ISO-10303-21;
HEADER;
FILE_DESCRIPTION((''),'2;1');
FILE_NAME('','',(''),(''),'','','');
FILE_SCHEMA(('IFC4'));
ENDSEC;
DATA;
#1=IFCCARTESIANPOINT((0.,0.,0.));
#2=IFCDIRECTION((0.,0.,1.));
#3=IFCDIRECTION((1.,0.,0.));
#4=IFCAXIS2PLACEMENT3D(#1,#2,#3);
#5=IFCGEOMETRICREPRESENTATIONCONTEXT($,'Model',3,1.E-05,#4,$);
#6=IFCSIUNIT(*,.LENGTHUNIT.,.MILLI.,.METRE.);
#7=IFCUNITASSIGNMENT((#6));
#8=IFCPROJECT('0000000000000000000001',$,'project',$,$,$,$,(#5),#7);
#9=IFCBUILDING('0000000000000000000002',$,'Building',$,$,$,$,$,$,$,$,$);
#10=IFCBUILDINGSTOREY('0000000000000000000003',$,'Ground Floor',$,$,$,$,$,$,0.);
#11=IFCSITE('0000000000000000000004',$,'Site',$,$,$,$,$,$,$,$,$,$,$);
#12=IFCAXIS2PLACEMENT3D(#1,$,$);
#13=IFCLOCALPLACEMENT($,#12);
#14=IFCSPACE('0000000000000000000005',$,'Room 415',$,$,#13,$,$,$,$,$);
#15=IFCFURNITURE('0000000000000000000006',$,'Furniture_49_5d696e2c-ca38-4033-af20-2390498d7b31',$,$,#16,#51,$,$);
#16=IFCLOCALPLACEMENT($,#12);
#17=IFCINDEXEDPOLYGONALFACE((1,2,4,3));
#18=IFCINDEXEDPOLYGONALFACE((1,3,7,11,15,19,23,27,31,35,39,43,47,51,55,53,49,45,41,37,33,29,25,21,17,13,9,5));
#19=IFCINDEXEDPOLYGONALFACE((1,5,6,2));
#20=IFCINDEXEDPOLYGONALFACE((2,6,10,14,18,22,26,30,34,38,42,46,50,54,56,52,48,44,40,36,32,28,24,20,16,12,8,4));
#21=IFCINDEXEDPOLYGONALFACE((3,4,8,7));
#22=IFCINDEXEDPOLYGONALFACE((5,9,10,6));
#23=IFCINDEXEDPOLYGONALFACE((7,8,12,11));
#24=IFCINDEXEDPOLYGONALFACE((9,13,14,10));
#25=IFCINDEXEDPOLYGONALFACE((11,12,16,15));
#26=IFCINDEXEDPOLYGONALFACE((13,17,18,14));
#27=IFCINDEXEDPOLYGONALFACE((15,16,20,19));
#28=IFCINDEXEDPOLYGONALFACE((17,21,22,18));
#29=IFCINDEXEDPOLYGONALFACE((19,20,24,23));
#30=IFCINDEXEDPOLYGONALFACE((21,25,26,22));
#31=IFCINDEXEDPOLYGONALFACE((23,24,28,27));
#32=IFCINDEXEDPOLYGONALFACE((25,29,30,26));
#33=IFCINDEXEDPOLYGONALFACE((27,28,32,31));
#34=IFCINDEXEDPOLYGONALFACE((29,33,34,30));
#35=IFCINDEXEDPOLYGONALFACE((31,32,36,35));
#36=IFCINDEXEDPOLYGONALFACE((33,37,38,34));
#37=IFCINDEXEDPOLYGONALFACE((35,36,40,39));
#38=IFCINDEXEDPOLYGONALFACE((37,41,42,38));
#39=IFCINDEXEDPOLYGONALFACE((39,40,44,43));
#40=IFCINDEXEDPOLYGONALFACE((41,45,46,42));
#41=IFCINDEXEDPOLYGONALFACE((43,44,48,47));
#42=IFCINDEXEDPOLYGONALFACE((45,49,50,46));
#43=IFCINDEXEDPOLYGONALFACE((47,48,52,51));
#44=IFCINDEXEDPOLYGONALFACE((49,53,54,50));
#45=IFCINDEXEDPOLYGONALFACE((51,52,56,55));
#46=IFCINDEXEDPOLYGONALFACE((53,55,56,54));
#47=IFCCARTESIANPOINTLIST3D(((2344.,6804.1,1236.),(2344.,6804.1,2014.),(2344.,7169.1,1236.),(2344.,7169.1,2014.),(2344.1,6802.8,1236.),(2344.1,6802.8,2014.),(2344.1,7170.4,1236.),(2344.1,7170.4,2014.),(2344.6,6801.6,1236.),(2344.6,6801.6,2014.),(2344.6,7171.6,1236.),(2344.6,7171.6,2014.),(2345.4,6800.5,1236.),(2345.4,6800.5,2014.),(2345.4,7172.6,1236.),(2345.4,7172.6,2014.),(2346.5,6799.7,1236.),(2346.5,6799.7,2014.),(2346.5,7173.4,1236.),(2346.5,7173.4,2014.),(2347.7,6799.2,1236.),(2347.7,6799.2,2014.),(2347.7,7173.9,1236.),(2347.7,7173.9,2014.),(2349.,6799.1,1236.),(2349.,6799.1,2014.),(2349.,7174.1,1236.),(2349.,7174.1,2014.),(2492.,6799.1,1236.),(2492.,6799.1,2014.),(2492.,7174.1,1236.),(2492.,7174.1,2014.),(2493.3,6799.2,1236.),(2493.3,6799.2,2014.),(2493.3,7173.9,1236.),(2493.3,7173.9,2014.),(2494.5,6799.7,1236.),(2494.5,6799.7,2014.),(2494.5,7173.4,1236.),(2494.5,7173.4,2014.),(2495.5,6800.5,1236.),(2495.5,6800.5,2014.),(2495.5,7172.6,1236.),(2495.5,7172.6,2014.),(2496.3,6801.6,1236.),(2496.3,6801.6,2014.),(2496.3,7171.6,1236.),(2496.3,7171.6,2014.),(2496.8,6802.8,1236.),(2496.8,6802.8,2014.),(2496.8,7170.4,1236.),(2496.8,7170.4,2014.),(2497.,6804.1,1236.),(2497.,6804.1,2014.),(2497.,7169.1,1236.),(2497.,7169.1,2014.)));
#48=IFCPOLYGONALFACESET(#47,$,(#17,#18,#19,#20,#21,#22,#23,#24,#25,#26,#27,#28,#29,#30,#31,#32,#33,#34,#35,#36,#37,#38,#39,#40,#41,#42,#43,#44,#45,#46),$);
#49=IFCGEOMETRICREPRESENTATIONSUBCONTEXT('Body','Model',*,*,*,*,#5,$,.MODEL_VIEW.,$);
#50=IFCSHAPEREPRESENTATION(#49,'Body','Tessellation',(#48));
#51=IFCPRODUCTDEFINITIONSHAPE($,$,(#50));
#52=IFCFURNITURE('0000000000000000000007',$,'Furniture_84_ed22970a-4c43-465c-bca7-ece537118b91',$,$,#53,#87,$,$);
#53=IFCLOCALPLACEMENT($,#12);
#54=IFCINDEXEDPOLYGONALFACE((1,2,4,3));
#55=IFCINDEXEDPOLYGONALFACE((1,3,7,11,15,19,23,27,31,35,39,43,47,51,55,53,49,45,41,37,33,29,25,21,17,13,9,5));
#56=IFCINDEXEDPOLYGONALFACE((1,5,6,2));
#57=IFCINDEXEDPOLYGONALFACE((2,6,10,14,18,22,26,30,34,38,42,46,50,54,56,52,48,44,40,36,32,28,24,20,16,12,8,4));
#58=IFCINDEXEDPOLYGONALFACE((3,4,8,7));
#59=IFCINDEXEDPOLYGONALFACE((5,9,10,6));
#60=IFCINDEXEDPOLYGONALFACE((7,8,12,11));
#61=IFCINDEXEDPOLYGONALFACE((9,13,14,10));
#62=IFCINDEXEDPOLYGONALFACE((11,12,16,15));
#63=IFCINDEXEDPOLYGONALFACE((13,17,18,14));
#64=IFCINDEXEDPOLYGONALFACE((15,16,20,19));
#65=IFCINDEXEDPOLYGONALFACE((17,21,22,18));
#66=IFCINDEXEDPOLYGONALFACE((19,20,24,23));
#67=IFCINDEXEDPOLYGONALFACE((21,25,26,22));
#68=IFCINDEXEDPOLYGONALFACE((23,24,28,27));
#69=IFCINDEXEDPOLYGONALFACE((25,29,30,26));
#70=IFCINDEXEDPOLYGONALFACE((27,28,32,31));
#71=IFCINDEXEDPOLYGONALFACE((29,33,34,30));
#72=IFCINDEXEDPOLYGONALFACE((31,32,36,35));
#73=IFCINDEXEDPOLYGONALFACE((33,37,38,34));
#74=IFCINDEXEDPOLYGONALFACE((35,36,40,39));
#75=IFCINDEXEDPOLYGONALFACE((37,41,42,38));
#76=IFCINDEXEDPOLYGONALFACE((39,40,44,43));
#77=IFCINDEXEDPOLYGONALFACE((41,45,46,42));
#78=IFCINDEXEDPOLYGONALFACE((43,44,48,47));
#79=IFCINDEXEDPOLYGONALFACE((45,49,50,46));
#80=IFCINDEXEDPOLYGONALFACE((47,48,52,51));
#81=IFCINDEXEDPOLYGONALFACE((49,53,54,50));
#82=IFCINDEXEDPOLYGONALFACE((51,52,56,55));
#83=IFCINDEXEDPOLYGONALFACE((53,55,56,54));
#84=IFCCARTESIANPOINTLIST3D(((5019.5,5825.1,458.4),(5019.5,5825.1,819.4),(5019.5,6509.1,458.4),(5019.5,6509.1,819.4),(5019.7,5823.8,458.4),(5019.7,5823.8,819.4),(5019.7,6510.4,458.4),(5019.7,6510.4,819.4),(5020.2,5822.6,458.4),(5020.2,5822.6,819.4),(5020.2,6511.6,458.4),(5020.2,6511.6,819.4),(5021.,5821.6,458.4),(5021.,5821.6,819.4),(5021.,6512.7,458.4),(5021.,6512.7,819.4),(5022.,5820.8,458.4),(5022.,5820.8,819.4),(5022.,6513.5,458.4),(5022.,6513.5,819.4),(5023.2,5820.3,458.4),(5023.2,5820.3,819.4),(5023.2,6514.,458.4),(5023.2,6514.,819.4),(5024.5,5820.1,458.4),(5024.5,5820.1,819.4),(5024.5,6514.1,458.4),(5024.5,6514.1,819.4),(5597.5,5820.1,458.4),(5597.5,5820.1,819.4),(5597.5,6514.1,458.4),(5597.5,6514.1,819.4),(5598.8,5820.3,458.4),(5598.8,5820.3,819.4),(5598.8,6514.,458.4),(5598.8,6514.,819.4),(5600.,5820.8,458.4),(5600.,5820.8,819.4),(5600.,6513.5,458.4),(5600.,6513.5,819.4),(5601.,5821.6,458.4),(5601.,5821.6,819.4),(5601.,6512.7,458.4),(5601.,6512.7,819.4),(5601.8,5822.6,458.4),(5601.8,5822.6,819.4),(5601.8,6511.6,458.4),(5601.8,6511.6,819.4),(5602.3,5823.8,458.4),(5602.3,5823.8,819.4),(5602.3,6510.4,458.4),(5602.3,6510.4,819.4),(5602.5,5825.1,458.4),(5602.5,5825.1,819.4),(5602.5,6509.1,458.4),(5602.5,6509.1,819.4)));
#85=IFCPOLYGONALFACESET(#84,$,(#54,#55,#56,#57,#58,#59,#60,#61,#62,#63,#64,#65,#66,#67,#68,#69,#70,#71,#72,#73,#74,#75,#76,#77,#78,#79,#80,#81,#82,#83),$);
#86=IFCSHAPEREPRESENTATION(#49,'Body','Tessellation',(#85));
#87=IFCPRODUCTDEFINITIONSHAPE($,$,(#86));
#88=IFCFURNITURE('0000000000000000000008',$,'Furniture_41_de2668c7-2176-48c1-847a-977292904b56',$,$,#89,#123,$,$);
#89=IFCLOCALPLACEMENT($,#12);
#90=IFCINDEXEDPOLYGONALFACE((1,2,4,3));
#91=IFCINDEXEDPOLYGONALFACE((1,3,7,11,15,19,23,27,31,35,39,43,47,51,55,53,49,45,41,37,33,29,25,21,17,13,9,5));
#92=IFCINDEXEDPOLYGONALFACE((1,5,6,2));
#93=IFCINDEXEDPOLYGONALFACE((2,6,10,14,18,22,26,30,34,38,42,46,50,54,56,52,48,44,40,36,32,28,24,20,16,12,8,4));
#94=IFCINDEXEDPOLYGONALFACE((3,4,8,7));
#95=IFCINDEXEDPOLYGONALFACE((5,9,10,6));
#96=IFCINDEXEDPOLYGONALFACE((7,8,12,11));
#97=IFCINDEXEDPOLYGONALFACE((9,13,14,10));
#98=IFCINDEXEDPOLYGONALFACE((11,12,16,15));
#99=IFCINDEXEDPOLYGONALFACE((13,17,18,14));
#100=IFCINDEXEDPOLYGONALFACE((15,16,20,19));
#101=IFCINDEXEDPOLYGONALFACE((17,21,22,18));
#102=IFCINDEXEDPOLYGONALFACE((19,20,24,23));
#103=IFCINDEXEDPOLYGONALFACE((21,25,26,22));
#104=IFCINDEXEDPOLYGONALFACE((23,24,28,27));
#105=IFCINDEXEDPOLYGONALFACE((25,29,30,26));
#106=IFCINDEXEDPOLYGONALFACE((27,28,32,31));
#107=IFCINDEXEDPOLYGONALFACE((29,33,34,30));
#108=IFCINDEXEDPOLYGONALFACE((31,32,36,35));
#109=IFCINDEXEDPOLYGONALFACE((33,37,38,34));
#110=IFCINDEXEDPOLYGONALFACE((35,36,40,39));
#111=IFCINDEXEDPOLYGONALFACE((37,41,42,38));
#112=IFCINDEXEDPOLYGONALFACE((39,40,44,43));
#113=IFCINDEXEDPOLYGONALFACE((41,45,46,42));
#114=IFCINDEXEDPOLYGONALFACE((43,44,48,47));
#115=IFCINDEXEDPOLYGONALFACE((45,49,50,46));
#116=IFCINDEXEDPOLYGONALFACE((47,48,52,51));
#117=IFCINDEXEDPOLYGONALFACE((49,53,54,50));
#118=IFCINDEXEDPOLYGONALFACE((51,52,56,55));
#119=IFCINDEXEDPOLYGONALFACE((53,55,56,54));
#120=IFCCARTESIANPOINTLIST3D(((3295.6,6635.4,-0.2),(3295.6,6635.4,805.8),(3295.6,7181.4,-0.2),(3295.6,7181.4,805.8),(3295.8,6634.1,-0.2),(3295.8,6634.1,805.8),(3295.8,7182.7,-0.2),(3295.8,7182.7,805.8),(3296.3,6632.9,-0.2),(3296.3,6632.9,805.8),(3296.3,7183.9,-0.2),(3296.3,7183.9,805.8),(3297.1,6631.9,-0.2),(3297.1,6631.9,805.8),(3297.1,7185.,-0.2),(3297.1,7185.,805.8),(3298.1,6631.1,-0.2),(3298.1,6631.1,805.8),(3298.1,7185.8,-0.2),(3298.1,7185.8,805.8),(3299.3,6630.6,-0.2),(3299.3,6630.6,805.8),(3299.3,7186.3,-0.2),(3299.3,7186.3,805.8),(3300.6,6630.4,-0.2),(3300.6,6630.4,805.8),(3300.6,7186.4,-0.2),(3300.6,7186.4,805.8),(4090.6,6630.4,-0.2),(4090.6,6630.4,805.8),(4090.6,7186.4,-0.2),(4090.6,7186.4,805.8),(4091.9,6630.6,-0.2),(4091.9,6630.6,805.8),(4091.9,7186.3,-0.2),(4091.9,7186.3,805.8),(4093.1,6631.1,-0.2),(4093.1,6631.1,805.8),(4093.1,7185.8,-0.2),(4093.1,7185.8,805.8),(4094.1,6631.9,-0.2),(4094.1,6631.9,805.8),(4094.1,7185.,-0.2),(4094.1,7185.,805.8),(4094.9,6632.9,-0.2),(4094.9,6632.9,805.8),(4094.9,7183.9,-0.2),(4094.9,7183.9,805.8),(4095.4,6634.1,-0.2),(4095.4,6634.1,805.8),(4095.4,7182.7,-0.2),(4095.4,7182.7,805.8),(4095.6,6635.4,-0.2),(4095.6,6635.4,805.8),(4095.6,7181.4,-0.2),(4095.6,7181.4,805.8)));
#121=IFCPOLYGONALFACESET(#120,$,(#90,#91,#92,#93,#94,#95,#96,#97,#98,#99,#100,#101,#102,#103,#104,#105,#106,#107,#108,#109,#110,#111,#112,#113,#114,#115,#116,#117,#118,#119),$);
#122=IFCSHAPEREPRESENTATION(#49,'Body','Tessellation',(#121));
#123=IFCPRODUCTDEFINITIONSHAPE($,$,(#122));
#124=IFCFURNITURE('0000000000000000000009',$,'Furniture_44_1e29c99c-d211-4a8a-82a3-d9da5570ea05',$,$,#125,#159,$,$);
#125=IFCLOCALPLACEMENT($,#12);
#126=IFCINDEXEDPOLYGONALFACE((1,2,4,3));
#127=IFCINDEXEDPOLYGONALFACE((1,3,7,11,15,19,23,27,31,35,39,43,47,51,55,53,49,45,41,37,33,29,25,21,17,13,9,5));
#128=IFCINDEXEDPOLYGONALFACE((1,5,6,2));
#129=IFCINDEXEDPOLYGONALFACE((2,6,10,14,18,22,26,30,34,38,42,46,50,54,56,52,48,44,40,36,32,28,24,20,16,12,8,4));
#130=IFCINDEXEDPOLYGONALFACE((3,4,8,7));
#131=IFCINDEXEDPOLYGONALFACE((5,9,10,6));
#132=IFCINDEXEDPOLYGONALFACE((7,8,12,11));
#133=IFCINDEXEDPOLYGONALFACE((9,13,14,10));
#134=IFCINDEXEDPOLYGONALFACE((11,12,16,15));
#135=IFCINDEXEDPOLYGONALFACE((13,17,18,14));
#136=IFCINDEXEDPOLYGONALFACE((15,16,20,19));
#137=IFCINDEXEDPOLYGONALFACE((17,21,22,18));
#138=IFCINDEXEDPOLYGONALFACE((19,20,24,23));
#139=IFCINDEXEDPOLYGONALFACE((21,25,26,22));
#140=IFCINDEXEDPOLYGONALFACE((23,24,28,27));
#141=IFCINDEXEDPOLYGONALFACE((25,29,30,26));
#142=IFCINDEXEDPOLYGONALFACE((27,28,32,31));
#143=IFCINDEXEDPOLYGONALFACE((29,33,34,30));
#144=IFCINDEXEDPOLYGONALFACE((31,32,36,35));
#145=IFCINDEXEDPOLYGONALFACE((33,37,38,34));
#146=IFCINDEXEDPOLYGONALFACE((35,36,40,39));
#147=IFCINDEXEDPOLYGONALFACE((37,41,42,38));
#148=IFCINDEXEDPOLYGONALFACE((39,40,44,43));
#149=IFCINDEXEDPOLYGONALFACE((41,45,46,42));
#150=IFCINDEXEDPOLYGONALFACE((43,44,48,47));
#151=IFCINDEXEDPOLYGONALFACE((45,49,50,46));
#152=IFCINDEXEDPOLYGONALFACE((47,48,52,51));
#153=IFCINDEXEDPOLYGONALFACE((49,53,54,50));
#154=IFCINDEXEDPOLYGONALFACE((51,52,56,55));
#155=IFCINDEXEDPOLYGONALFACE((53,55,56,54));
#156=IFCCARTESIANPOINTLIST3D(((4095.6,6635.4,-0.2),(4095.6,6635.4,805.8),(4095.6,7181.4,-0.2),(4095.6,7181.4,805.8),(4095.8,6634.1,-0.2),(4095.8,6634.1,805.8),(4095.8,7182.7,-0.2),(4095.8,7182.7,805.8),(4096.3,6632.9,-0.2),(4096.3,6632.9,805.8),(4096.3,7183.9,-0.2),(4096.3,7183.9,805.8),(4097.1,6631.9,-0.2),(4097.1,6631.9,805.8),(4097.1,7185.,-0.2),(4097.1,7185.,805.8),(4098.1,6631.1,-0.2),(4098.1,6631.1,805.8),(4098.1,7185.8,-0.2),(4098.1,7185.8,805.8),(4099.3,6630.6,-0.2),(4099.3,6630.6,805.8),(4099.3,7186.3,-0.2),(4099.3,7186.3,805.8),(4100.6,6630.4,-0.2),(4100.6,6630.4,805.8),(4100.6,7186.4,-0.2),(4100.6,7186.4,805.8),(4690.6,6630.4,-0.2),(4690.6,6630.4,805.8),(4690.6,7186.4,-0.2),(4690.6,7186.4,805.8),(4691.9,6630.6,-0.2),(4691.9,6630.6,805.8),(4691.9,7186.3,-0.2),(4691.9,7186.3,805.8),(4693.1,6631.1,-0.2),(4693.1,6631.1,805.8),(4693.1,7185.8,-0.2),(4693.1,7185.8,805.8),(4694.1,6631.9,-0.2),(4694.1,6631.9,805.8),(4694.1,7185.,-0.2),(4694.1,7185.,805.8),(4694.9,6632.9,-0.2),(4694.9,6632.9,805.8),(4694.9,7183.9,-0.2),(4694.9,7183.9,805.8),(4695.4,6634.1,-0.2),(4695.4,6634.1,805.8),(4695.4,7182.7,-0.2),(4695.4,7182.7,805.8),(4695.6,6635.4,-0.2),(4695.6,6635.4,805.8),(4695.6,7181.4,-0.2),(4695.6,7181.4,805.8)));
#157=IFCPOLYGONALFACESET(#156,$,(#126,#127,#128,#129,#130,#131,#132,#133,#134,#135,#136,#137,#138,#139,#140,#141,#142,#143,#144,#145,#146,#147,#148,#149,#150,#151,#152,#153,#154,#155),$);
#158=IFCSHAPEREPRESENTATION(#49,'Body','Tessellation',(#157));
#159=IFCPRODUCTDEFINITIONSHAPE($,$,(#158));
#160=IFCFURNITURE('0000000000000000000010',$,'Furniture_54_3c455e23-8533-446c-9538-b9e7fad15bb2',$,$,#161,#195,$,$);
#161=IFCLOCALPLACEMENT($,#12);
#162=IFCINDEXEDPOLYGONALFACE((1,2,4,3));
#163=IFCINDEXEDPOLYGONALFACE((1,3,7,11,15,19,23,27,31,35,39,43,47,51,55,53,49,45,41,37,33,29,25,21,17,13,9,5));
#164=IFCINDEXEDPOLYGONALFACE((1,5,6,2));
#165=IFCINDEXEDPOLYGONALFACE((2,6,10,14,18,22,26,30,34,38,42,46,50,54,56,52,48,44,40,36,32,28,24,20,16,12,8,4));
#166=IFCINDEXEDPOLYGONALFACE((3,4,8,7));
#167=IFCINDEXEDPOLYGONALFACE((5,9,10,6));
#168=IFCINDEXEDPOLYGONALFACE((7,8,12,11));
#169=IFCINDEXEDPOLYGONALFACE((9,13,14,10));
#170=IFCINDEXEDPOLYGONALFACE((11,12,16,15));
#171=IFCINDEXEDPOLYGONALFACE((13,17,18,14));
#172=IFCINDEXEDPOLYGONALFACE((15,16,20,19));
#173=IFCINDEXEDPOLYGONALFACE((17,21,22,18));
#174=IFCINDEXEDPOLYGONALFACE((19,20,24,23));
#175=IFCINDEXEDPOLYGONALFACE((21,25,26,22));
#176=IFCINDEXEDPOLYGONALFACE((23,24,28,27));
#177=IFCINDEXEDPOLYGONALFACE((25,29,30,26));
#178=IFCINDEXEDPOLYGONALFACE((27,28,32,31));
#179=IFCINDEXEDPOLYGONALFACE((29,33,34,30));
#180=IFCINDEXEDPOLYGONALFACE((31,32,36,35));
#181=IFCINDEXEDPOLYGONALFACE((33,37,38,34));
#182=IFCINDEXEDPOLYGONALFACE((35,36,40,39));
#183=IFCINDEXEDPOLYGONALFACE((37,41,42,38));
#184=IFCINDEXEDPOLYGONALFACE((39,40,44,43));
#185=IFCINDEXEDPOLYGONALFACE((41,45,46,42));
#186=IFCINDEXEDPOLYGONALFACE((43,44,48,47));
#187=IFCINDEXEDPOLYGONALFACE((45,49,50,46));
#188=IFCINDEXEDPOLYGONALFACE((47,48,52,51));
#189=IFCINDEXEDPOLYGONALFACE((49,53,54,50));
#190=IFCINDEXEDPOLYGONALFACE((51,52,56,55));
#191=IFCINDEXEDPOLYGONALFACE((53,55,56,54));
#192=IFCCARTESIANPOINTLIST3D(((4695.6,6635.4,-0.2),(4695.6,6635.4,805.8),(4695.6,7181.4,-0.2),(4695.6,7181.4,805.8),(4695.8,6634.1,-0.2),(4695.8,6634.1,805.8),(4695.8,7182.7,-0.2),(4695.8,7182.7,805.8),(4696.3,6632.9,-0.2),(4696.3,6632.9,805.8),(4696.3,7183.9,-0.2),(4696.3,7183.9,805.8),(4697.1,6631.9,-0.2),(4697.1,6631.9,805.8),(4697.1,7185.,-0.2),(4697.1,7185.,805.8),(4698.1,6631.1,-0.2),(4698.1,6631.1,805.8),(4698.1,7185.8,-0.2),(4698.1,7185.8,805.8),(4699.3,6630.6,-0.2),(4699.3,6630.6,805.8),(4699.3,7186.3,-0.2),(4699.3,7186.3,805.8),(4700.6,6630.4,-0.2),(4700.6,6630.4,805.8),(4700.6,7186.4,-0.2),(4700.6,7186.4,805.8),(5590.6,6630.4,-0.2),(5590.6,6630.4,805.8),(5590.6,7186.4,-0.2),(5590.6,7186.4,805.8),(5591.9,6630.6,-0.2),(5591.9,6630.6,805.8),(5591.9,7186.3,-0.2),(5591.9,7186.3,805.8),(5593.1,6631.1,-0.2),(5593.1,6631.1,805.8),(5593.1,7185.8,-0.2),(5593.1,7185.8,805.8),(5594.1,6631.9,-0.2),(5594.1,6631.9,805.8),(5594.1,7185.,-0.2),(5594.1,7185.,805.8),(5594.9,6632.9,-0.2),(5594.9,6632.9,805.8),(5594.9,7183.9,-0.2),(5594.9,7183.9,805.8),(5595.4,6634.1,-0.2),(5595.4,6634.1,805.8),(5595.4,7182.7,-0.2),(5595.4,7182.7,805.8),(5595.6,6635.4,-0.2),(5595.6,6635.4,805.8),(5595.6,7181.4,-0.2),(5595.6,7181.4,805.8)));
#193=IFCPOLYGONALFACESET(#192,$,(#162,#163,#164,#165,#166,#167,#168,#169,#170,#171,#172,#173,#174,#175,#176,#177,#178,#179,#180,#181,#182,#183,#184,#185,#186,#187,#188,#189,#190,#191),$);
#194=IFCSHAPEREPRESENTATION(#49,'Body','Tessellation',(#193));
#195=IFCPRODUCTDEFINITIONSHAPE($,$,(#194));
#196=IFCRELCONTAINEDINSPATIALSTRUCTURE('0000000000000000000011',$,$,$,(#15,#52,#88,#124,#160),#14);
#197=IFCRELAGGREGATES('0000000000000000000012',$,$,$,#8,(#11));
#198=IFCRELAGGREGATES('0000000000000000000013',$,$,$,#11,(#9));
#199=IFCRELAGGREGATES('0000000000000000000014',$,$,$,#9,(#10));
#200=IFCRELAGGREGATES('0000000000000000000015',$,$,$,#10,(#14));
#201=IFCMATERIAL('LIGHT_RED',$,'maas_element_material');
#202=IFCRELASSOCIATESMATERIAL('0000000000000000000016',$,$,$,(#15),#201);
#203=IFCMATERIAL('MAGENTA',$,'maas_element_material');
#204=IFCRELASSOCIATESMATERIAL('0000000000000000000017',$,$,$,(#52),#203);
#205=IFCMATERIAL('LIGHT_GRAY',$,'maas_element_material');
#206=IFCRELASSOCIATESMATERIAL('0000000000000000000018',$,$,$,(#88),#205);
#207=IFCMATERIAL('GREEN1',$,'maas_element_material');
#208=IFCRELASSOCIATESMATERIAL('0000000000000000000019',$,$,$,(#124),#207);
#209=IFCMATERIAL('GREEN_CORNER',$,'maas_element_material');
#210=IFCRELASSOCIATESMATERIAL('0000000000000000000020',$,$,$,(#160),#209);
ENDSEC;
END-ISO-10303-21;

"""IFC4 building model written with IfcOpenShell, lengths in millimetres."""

from ifc_helpers import new_model, si_unit, frame, origin, origin_with_axes, place, context, subcontext, project, spatial, rounded_rectangle, extrude, material, element, save


model = new_model("IFC4")

# Units and contexts
model_context = context("Model", 3, precision=1e-05, world=origin_with_axes())
body_context = subcontext(model_context, "Body", "Model", "MODEL_VIEW")
ifc_project = project(units=[si_unit("LENGTHUNIT", "METRE", prefix="MILLI")], contexts=[model_context])

# Site, building, storey, space
site = spatial("IfcSite", under=ifc_project, Name="Site")
building = spatial("IfcBuilding", under=site, Name="Building")
storey = spatial("IfcBuildingStorey", under=building, Name="Ground Floor", Elevation=0.0)
space_placement = place(None, origin())
space = spatial("IfcSpace", under=storey, at=space_placement, Name="Room 415")

# Furniture
ifc_material_1 = material(Name="LIGHT_RED", Category="maas_element_material")
furniture_1_placement = place(space_placement, frame((2420.5, 6986.6, 1625.0), z_axis=(0.0, 0.0, 1.0), x_axis=(0.0, 1.0, 0.0)))
element("IfcFurniture", 1, at=furniture_1_placement, inside=space, material=ifc_material_1, Name="Furniture_49_5d696e2c-ca38-4033-af20-2390498d7b31", context=body_context, shape_type="SweptSolid", body=[
    extrude(rounded_rectangle(XDim=375.0, YDim=153.0, RoundingRadius=5.0), frame((0.0, 0.0, -389.0), z_axis=(0.0, 0.0, 1.0), x_axis=(1.0, 0.0, 0.0)), (0.0, 0.0, 1.0), 778.0),
])
ifc_material_2 = material(Name="MAGENTA", Category="maas_element_material")
furniture_2_placement = place(space_placement, frame((5311.0, 6167.1, 638.9), z_axis=(0.0, 0.0, 1.0), x_axis=(0.0, -1.0, 0.0)))
element("IfcFurniture", 2, at=furniture_2_placement, inside=space, material=ifc_material_2, Name="Furniture_84_ed22970a-4c43-465c-bca7-ece537118b91", context=body_context, shape_type="SweptSolid", body=[
    extrude(rounded_rectangle(XDim=694.0, YDim=583.0, RoundingRadius=5.0), frame((0.0, 0.0, -180.5), z_axis=(0.0, 0.0, 1.0), x_axis=(1.0, 0.0, 0.0)), (0.0, 0.0, 1.0), 361.0),
])
ifc_material_3 = material(Name="LIGHT_GRAY", Category="maas_element_material")
furniture_3_placement = place(space_placement, frame((3695.6, 6908.4, 402.8), z_axis=(0.0, 0.0, 1.0), x_axis=(1.0, 0.0, 0.0)))
element("IfcFurniture", 3, at=furniture_3_placement, inside=space, material=ifc_material_3, Name="Furniture_41_de2668c7-2176-48c1-847a-977292904b56", context=body_context, shape_type="SweptSolid", body=[
    extrude(rounded_rectangle(XDim=800.0, YDim=556.0, RoundingRadius=5.0), frame((0.0, 0.0, -403.0), z_axis=(0.0, 0.0, 1.0), x_axis=(1.0, 0.0, 0.0)), (0.0, 0.0, 1.0), 806.0),
])
ifc_material_4 = material(Name="GREEN1", Category="maas_element_material")
furniture_4_placement = place(space_placement, frame((4395.6, 6908.4, 402.8), z_axis=(0.0, 0.0, 1.0), x_axis=(1.0, 0.0, 0.0)))
element("IfcFurniture", 4, at=furniture_4_placement, inside=space, material=ifc_material_4, Name="Furniture_44_1e29c99c-d211-4a8a-82a3-d9da5570ea05", context=body_context, shape_type="SweptSolid", body=[
    extrude(rounded_rectangle(XDim=600.0, YDim=556.0, RoundingRadius=5.0), frame((0.0, 0.0, -403.0), z_axis=(0.0, 0.0, 1.0), x_axis=(1.0, 0.0, 0.0)), (0.0, 0.0, 1.0), 806.0),
])
ifc_material_5 = material(Name="GREEN_CORNER", Category="maas_element_material")
furniture_5_placement = place(space_placement, frame((5145.6, 6908.4, 402.8), z_axis=(0.0, 0.0, 1.0), x_axis=(1.0, 0.0, 0.0)))
element("IfcFurniture", 5, at=furniture_5_placement, inside=space, material=ifc_material_5, Name="Furniture_54_3c455e23-8533-446c-9538-b9e7fad15bb2", context=body_context, shape_type="SweptSolid", body=[
    extrude(rounded_rectangle(XDim=900.0, YDim=556.0, RoundingRadius=5.0), frame((0.0, 0.0, -403.0), z_axis=(0.0, 0.0, 1.0), x_axis=(1.0, 0.0, 0.0)), (0.0, 0.0, 1.0), 806.0),
])

save(model, "model.ifc")
